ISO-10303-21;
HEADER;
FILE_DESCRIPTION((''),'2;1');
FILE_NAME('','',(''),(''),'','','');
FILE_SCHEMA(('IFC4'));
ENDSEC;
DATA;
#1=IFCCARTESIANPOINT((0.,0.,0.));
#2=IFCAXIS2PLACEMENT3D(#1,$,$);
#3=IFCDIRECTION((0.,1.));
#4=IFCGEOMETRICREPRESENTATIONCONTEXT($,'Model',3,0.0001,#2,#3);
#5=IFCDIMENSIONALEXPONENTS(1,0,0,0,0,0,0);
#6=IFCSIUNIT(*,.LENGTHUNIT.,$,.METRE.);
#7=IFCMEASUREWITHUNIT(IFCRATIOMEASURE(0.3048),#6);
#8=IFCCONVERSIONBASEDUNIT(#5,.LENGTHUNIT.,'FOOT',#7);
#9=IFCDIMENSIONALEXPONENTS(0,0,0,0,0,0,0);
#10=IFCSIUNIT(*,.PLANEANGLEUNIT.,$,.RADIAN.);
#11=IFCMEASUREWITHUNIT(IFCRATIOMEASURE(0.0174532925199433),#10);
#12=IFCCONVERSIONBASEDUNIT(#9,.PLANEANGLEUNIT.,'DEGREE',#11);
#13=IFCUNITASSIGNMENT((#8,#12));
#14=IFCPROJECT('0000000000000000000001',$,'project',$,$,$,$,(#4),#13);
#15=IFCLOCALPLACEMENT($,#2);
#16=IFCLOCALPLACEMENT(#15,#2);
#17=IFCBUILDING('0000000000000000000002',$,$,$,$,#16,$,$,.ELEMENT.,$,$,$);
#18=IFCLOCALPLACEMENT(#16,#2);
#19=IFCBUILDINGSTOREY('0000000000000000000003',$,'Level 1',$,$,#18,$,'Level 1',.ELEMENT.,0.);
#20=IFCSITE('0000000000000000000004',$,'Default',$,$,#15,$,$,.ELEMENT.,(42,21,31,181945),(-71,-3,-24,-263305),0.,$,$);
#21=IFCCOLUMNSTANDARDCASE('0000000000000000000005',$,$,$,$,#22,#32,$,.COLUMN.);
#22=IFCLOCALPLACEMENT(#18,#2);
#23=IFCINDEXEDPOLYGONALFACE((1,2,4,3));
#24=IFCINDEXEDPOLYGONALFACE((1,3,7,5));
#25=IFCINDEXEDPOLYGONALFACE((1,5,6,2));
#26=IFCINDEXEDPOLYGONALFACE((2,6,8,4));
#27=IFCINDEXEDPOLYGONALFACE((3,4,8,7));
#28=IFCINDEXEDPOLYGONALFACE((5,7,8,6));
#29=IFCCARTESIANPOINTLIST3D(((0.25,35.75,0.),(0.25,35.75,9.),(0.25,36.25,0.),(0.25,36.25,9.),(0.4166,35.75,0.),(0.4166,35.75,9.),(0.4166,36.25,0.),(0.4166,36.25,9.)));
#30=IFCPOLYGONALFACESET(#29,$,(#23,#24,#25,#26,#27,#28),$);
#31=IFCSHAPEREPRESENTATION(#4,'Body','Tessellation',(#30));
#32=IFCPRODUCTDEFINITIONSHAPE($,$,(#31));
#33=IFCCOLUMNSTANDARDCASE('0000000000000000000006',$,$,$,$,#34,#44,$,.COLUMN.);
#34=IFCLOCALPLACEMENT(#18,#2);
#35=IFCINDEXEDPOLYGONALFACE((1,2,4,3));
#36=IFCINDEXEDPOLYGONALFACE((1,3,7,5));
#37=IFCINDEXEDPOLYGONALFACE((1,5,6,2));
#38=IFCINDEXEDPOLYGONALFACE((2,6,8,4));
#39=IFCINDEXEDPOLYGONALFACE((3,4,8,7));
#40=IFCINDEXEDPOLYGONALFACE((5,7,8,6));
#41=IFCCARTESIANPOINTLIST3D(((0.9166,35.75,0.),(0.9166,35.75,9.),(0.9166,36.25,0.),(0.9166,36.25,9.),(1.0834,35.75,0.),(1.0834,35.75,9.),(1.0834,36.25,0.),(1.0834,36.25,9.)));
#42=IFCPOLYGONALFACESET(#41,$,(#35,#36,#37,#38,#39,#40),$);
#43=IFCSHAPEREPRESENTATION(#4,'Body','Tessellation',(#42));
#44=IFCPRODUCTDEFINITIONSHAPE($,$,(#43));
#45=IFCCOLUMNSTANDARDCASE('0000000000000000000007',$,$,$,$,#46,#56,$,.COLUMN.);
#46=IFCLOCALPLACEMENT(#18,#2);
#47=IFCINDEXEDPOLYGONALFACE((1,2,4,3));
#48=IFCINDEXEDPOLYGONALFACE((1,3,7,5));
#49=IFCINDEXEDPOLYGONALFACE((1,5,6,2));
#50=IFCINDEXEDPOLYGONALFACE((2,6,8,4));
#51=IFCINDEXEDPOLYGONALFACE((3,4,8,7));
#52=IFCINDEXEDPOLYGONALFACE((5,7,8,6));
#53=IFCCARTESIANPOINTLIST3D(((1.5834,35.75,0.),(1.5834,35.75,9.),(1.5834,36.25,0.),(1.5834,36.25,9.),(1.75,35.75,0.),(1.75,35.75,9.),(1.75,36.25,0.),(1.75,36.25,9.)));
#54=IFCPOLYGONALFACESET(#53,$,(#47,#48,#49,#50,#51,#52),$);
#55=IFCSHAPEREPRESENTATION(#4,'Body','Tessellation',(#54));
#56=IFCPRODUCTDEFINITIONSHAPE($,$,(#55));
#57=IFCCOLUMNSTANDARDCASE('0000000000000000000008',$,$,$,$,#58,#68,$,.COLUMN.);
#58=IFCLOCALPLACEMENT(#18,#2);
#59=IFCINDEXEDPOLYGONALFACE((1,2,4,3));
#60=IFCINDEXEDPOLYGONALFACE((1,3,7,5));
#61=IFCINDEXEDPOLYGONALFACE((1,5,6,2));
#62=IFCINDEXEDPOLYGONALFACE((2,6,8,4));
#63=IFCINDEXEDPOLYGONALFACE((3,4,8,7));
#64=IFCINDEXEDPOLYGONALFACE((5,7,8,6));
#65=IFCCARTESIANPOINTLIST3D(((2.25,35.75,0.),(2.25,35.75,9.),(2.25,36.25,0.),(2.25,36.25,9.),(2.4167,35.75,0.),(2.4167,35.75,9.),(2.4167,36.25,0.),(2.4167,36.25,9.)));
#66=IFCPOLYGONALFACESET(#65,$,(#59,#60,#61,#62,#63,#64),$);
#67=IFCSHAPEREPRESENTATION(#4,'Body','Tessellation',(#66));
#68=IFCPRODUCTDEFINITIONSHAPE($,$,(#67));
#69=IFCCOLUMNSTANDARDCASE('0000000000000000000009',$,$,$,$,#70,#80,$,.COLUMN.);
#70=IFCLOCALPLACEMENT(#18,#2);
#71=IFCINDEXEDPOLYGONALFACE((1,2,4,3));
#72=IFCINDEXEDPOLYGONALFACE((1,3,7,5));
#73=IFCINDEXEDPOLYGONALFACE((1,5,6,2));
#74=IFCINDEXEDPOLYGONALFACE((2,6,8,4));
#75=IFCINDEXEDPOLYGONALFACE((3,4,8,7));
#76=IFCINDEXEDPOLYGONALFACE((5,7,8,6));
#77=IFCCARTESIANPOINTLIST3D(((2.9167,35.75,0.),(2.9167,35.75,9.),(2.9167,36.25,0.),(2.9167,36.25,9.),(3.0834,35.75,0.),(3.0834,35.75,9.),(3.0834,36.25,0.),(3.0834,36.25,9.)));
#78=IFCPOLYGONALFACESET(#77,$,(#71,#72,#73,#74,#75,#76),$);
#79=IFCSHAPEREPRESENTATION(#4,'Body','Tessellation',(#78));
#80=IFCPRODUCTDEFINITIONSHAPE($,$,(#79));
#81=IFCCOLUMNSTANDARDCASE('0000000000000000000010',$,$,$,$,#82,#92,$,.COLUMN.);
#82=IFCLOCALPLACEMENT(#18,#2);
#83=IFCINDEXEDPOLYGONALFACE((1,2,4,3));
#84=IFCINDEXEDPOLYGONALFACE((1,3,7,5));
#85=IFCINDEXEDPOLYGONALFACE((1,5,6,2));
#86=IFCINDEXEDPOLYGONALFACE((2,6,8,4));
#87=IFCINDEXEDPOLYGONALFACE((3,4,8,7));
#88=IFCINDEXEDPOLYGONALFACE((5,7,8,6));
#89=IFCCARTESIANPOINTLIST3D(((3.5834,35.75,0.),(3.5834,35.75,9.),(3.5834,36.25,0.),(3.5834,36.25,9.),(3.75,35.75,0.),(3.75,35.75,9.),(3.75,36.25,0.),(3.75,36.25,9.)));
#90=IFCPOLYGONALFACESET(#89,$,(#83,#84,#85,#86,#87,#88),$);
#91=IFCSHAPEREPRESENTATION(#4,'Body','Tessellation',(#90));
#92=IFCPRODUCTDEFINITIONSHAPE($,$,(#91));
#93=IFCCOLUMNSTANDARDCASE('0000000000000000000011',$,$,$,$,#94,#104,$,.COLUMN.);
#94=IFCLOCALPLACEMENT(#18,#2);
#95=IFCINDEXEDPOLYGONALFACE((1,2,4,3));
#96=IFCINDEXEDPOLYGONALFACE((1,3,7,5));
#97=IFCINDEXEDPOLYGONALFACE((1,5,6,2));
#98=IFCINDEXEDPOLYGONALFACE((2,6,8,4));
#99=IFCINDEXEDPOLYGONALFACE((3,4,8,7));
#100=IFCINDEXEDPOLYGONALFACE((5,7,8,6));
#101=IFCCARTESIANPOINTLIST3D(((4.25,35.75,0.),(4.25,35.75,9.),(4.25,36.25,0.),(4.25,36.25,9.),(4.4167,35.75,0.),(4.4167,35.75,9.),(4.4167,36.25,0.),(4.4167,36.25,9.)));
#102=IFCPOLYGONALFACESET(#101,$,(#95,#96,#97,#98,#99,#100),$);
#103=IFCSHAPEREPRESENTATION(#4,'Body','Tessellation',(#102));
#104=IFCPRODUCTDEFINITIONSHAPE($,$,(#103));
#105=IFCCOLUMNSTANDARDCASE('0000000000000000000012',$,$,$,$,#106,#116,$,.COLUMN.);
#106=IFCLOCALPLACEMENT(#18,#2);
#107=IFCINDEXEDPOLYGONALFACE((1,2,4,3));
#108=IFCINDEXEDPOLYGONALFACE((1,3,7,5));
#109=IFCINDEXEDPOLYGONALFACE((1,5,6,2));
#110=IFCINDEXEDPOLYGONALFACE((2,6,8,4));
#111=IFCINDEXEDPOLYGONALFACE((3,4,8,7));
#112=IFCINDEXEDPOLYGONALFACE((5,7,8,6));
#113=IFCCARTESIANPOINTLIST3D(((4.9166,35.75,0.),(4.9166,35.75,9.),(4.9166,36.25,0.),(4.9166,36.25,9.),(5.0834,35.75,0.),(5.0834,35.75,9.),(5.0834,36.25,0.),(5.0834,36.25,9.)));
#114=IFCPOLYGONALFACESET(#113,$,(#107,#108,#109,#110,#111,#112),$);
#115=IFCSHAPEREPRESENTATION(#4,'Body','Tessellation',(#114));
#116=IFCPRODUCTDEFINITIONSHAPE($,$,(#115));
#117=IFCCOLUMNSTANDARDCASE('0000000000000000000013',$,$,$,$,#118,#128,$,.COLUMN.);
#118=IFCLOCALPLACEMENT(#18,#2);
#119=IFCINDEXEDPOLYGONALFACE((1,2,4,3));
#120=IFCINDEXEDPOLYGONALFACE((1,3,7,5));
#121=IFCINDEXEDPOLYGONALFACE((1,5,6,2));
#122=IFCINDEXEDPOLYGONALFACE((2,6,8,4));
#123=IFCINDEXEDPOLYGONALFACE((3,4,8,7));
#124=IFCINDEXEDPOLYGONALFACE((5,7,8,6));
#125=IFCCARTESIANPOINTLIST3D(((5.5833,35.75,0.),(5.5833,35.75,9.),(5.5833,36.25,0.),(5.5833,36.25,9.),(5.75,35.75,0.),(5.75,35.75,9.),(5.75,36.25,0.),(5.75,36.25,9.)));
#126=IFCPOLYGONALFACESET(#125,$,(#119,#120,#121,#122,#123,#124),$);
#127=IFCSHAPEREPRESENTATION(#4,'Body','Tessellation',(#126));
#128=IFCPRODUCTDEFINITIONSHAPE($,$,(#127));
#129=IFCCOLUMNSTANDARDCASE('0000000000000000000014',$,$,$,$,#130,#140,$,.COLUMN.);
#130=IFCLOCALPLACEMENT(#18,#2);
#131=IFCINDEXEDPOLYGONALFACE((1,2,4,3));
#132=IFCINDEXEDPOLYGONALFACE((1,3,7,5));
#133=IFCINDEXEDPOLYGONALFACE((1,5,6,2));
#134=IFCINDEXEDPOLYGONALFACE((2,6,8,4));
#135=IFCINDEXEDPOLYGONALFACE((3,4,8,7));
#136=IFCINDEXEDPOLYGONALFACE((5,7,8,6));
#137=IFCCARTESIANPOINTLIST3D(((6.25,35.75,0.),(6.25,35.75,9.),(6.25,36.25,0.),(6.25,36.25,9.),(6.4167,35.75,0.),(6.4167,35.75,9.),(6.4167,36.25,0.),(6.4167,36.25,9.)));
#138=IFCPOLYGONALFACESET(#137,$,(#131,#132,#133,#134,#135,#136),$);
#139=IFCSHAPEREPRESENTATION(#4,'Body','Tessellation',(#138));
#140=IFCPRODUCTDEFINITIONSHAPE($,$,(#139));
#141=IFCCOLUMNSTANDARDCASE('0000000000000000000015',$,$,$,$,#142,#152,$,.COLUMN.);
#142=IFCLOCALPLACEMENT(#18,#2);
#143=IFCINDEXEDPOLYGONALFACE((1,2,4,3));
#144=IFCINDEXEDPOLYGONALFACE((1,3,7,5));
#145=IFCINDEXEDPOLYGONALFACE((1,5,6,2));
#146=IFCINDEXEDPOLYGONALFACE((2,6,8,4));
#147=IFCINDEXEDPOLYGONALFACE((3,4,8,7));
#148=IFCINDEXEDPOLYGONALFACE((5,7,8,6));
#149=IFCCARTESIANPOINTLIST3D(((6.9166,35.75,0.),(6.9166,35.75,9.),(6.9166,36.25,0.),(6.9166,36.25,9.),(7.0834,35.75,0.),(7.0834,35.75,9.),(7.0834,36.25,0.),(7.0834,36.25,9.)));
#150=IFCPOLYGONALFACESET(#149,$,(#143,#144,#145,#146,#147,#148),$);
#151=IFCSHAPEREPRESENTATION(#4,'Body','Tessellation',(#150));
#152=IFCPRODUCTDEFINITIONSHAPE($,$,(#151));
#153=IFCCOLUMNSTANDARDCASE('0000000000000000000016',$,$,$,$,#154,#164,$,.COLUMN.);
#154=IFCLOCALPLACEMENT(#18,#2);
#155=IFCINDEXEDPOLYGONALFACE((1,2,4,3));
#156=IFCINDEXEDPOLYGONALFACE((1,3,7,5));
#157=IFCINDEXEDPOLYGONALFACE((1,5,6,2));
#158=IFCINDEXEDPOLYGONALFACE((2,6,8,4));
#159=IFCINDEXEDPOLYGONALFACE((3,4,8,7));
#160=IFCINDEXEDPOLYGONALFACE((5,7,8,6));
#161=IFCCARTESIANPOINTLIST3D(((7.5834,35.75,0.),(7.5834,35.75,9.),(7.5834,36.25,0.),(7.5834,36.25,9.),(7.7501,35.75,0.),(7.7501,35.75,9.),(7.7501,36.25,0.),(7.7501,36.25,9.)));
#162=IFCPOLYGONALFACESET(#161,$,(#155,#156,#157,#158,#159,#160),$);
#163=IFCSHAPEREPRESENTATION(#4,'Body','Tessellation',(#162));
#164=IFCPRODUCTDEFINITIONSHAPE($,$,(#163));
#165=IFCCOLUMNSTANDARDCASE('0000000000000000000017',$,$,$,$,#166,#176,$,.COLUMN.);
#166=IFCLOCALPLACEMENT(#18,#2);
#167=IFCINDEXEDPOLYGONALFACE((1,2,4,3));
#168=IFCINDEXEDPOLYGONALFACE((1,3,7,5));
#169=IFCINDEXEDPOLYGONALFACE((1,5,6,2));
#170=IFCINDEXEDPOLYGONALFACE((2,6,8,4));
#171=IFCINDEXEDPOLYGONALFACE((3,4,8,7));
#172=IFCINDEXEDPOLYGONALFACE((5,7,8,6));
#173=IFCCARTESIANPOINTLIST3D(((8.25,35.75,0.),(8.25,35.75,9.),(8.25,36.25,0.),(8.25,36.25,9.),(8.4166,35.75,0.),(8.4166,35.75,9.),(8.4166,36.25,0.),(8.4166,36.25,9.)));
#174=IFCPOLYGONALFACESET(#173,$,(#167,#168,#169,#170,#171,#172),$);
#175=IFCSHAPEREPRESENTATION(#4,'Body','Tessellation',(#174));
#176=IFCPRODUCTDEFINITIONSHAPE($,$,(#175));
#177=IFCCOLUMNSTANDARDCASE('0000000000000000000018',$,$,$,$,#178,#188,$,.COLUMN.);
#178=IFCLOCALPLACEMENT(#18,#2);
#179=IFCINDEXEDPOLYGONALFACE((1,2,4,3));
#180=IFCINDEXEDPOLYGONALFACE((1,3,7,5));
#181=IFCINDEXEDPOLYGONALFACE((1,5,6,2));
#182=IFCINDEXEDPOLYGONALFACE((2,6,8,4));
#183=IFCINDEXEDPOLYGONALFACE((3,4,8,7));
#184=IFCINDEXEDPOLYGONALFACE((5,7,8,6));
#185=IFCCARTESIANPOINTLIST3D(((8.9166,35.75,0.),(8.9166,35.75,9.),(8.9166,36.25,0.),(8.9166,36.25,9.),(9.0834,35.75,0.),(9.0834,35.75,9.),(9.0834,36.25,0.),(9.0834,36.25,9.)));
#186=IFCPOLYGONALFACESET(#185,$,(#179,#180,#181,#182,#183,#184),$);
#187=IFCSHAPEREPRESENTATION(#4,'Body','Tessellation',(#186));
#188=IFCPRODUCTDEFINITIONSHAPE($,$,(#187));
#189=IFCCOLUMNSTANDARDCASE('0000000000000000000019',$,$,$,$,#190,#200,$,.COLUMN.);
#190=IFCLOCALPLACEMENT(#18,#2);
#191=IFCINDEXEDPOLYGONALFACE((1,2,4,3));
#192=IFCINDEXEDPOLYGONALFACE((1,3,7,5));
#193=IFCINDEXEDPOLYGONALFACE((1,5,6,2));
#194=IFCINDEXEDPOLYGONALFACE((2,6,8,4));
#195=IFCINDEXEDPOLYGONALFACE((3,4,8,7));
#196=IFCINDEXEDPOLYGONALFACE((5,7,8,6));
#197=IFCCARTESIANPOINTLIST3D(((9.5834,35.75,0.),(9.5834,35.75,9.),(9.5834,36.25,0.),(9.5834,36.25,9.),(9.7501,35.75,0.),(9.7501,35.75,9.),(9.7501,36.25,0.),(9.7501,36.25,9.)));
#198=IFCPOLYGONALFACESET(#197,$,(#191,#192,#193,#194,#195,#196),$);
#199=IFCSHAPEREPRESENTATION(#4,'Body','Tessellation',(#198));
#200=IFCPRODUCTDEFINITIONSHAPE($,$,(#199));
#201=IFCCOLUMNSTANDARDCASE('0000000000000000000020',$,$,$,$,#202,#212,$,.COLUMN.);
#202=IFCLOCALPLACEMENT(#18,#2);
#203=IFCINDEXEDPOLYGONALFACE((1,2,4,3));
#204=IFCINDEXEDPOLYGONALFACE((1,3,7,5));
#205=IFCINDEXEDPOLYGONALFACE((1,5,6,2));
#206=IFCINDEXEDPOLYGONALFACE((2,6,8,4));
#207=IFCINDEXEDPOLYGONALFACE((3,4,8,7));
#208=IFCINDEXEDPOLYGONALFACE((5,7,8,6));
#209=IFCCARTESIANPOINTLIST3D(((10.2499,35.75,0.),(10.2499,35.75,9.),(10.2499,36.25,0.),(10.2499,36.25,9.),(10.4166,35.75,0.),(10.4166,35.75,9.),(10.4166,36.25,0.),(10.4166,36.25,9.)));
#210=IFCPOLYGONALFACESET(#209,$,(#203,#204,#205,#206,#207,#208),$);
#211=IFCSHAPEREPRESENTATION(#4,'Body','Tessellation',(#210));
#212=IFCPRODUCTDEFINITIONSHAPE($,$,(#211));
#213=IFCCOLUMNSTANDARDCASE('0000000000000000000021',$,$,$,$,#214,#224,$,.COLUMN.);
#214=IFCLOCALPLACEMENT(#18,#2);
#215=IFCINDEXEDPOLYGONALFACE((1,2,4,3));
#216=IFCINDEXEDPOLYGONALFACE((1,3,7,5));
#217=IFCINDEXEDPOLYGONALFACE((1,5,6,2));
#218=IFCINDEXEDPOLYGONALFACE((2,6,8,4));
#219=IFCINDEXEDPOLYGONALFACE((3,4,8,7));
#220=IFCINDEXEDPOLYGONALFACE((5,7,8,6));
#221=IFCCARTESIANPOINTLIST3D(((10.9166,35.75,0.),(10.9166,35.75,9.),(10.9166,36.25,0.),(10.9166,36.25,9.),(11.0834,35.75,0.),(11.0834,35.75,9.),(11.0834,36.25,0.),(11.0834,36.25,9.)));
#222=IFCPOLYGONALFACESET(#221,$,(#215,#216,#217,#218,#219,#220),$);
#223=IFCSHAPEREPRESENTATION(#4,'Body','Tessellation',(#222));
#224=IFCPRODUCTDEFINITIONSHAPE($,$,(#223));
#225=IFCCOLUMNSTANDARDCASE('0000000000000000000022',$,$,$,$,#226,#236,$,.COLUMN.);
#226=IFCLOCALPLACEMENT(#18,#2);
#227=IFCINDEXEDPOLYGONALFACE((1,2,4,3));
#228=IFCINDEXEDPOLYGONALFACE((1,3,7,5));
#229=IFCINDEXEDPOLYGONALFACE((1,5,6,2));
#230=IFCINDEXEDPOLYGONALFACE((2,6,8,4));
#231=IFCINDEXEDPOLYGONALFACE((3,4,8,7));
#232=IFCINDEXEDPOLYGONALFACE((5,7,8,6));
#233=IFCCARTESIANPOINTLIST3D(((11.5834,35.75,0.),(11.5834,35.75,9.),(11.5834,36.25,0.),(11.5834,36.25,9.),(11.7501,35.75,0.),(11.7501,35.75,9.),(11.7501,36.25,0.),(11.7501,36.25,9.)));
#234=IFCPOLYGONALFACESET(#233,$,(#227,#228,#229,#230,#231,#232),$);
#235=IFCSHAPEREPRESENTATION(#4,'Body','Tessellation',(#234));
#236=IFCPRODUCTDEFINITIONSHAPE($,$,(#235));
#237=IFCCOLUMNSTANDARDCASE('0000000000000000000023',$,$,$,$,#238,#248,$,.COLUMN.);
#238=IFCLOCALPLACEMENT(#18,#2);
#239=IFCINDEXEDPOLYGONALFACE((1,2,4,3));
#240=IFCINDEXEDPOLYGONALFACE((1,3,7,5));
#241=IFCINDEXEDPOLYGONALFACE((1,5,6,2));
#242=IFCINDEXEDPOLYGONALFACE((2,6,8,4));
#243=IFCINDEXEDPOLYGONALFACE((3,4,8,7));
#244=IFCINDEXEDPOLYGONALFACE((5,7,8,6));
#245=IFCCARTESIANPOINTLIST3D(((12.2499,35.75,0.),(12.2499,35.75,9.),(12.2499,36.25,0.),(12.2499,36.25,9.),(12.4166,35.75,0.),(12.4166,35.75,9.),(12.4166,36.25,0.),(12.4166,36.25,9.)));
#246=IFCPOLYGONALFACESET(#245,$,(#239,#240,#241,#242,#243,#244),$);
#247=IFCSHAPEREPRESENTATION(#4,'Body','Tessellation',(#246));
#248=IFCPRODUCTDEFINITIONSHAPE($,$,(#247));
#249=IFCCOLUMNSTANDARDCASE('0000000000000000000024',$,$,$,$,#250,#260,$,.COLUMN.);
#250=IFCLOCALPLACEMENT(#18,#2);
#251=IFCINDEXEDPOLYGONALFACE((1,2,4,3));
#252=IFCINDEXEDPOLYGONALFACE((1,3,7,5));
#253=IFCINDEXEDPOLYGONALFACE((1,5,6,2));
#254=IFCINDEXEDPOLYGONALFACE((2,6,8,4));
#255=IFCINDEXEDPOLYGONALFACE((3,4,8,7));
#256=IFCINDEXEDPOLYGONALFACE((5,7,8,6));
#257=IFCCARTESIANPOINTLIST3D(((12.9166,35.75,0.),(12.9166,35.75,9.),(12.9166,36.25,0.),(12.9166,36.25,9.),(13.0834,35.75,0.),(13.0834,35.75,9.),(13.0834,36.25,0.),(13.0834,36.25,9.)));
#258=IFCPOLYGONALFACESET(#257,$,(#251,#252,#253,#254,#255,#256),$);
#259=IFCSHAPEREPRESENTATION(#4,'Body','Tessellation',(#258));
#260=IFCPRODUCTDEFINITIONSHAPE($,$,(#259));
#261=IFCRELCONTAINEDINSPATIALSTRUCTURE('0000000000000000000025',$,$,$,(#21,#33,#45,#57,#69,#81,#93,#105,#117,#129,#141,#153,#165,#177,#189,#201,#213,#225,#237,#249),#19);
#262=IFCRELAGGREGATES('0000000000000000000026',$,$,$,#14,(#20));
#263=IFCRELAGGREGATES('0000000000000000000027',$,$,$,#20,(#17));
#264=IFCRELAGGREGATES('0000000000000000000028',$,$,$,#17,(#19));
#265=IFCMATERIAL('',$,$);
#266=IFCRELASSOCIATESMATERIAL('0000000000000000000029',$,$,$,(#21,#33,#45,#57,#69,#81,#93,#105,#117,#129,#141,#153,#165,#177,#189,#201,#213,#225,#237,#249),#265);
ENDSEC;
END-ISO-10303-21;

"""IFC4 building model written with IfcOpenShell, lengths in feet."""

from ifc_helpers import new_model, entity, si_unit, converted_unit, direction, frame, origin, place, context, project, spatial, rectangle, extrude, material, element, save


model = new_model("IFC4")

# Units and contexts
model_context = context("Model", 3, precision=0.0001, world=origin(), true_north=direction((0.0, 1.0)))
ifc_project = project(units=[converted_unit("LENGTHUNIT", "FOOT", entity("IfcRatioMeasure", 0.3048), si_unit("LENGTHUNIT", "METRE"), dimensions=[1, 0, 0, 0, 0, 0, 0]), converted_unit("PLANEANGLEUNIT", "DEGREE", entity("IfcRatioMeasure", 0.0174532925199433), si_unit("PLANEANGLEUNIT", "RADIAN"), dimensions=[0, 0, 0, 0, 0, 0, 0])], contexts=[model_context])

# Site, building, storey
site_placement = place(None, origin())
site = spatial("IfcSite", under=ifc_project, at=site_placement, Name="Default", CompositionType="ELEMENT", RefLatitude=(42, 21, 31, 181945), RefLongitude=(-71, -3, -24, -263305), RefElevation=0.0)
building_placement = place(site_placement, origin())
building = spatial("IfcBuilding", under=site, at=building_placement, CompositionType="ELEMENT")
storey_placement = place(building_placement, origin())
storey = spatial("IfcBuildingStorey", under=building, at=storey_placement, Name="Level 1", LongName="Level 1", CompositionType="ELEMENT", Elevation=0.0)

# Columns
ifc_material_1 = material(Name="")
placement = place(storey_placement, frame((0.25, 36.0, 0.0)))
for number, where, z_axis, x_axis in (
    (1, (0.0833, 0.0, 0.0), (0.0, 0.0, 1.0), (1.0, 0.0, 0.0)),
    (2, (0.75, 0.0, 0.0), (0.0, 0.0, 1.0), (1.0, 0.0, 0.0)),
    (3, (1.4167, 0.0, 0.0), (0.0, 0.0, 1.0), (1.0, 0.0, 0.0)),
    (4, (2.0833, 0.0, 0.0), (0.0, 0.0, 1.0), (1.0, 0.0, 0.0)),
    (5, (2.75, 0.0, 0.0), (0.0, 0.0, 1.0), (1.0, 0.0, 0.0)),
    (6, (3.4167, 0.0, 0.0), (0.0, 0.0, 1.0), (1.0, 0.0, 0.0)),
    (7, (4.0833, 0.0, 0.0), (0.0, 0.0, 1.0), (1.0, 0.0, 0.0)),
    (8, (4.75, 0.0, 0.0), (0.0, 0.0, 1.0), (1.0, 0.0, 0.0)),
    (9, (5.4167, 0.0, 0.0), (0.0, 0.0, 1.0), (1.0, 0.0, 0.0)),
    (10, (6.0833, 0.0, 0.0), (0.0, 0.0, 1.0), (1.0, 0.0, 0.0)),
    (11, (6.75, 0.0, 0.0), (0.0, 0.0, 1.0), (1.0, 0.0, 0.0)),
    (12, (7.4167, 0.0, 0.0), (0.0, 0.0, 1.0), (1.0, 0.0, 0.0)),
    (13, (8.0833, 0.0, 0.0), (0.0, 0.0, 1.0), (1.0, 0.0, 0.0)),
    (14, (8.75, 0.0, 0.0), (0.0, 0.0, 1.0), (1.0, 0.0, 0.0)),
    (15, (9.4167, 0.0, 0.0), (0.0, 0.0, 1.0), (1.0, 0.0, 0.0)),
    (16, (10.0833, 0.0, 0.0), (0.0, 0.0, 1.0), (1.0, 0.0, 0.0)),
    (17, (10.75, 0.0, 0.0), (0.0, 0.0, 1.0), (1.0, 0.0, 0.0)),
    (18, (11.4167, 0.0, 0.0), (0.0, 0.0, 1.0), (1.0, 0.0, 0.0)),
    (19, (12.0833, 0.0, 0.0), (0.0, 0.0, 1.0), (1.0, 0.0, 0.0)),
    (20, (12.75, 0.0, 0.0), (0.0, 0.0, 1.0), (1.0, 0.0, 0.0)),
):
    element("IfcColumnStandardCase", number, at=place(placement, frame(where, z_axis=z_axis, x_axis=x_axis)), inside=storey, material=ifc_material_1, PredefinedType="COLUMN", context=model_context, shape_type="SweptSolid", body=[
        extrude(rectangle(XDim=0.1667, YDim=0.5), origin(), (0.0, 0.0, 1.0), 9.0),
    ])

save(model, "model.ifc")
